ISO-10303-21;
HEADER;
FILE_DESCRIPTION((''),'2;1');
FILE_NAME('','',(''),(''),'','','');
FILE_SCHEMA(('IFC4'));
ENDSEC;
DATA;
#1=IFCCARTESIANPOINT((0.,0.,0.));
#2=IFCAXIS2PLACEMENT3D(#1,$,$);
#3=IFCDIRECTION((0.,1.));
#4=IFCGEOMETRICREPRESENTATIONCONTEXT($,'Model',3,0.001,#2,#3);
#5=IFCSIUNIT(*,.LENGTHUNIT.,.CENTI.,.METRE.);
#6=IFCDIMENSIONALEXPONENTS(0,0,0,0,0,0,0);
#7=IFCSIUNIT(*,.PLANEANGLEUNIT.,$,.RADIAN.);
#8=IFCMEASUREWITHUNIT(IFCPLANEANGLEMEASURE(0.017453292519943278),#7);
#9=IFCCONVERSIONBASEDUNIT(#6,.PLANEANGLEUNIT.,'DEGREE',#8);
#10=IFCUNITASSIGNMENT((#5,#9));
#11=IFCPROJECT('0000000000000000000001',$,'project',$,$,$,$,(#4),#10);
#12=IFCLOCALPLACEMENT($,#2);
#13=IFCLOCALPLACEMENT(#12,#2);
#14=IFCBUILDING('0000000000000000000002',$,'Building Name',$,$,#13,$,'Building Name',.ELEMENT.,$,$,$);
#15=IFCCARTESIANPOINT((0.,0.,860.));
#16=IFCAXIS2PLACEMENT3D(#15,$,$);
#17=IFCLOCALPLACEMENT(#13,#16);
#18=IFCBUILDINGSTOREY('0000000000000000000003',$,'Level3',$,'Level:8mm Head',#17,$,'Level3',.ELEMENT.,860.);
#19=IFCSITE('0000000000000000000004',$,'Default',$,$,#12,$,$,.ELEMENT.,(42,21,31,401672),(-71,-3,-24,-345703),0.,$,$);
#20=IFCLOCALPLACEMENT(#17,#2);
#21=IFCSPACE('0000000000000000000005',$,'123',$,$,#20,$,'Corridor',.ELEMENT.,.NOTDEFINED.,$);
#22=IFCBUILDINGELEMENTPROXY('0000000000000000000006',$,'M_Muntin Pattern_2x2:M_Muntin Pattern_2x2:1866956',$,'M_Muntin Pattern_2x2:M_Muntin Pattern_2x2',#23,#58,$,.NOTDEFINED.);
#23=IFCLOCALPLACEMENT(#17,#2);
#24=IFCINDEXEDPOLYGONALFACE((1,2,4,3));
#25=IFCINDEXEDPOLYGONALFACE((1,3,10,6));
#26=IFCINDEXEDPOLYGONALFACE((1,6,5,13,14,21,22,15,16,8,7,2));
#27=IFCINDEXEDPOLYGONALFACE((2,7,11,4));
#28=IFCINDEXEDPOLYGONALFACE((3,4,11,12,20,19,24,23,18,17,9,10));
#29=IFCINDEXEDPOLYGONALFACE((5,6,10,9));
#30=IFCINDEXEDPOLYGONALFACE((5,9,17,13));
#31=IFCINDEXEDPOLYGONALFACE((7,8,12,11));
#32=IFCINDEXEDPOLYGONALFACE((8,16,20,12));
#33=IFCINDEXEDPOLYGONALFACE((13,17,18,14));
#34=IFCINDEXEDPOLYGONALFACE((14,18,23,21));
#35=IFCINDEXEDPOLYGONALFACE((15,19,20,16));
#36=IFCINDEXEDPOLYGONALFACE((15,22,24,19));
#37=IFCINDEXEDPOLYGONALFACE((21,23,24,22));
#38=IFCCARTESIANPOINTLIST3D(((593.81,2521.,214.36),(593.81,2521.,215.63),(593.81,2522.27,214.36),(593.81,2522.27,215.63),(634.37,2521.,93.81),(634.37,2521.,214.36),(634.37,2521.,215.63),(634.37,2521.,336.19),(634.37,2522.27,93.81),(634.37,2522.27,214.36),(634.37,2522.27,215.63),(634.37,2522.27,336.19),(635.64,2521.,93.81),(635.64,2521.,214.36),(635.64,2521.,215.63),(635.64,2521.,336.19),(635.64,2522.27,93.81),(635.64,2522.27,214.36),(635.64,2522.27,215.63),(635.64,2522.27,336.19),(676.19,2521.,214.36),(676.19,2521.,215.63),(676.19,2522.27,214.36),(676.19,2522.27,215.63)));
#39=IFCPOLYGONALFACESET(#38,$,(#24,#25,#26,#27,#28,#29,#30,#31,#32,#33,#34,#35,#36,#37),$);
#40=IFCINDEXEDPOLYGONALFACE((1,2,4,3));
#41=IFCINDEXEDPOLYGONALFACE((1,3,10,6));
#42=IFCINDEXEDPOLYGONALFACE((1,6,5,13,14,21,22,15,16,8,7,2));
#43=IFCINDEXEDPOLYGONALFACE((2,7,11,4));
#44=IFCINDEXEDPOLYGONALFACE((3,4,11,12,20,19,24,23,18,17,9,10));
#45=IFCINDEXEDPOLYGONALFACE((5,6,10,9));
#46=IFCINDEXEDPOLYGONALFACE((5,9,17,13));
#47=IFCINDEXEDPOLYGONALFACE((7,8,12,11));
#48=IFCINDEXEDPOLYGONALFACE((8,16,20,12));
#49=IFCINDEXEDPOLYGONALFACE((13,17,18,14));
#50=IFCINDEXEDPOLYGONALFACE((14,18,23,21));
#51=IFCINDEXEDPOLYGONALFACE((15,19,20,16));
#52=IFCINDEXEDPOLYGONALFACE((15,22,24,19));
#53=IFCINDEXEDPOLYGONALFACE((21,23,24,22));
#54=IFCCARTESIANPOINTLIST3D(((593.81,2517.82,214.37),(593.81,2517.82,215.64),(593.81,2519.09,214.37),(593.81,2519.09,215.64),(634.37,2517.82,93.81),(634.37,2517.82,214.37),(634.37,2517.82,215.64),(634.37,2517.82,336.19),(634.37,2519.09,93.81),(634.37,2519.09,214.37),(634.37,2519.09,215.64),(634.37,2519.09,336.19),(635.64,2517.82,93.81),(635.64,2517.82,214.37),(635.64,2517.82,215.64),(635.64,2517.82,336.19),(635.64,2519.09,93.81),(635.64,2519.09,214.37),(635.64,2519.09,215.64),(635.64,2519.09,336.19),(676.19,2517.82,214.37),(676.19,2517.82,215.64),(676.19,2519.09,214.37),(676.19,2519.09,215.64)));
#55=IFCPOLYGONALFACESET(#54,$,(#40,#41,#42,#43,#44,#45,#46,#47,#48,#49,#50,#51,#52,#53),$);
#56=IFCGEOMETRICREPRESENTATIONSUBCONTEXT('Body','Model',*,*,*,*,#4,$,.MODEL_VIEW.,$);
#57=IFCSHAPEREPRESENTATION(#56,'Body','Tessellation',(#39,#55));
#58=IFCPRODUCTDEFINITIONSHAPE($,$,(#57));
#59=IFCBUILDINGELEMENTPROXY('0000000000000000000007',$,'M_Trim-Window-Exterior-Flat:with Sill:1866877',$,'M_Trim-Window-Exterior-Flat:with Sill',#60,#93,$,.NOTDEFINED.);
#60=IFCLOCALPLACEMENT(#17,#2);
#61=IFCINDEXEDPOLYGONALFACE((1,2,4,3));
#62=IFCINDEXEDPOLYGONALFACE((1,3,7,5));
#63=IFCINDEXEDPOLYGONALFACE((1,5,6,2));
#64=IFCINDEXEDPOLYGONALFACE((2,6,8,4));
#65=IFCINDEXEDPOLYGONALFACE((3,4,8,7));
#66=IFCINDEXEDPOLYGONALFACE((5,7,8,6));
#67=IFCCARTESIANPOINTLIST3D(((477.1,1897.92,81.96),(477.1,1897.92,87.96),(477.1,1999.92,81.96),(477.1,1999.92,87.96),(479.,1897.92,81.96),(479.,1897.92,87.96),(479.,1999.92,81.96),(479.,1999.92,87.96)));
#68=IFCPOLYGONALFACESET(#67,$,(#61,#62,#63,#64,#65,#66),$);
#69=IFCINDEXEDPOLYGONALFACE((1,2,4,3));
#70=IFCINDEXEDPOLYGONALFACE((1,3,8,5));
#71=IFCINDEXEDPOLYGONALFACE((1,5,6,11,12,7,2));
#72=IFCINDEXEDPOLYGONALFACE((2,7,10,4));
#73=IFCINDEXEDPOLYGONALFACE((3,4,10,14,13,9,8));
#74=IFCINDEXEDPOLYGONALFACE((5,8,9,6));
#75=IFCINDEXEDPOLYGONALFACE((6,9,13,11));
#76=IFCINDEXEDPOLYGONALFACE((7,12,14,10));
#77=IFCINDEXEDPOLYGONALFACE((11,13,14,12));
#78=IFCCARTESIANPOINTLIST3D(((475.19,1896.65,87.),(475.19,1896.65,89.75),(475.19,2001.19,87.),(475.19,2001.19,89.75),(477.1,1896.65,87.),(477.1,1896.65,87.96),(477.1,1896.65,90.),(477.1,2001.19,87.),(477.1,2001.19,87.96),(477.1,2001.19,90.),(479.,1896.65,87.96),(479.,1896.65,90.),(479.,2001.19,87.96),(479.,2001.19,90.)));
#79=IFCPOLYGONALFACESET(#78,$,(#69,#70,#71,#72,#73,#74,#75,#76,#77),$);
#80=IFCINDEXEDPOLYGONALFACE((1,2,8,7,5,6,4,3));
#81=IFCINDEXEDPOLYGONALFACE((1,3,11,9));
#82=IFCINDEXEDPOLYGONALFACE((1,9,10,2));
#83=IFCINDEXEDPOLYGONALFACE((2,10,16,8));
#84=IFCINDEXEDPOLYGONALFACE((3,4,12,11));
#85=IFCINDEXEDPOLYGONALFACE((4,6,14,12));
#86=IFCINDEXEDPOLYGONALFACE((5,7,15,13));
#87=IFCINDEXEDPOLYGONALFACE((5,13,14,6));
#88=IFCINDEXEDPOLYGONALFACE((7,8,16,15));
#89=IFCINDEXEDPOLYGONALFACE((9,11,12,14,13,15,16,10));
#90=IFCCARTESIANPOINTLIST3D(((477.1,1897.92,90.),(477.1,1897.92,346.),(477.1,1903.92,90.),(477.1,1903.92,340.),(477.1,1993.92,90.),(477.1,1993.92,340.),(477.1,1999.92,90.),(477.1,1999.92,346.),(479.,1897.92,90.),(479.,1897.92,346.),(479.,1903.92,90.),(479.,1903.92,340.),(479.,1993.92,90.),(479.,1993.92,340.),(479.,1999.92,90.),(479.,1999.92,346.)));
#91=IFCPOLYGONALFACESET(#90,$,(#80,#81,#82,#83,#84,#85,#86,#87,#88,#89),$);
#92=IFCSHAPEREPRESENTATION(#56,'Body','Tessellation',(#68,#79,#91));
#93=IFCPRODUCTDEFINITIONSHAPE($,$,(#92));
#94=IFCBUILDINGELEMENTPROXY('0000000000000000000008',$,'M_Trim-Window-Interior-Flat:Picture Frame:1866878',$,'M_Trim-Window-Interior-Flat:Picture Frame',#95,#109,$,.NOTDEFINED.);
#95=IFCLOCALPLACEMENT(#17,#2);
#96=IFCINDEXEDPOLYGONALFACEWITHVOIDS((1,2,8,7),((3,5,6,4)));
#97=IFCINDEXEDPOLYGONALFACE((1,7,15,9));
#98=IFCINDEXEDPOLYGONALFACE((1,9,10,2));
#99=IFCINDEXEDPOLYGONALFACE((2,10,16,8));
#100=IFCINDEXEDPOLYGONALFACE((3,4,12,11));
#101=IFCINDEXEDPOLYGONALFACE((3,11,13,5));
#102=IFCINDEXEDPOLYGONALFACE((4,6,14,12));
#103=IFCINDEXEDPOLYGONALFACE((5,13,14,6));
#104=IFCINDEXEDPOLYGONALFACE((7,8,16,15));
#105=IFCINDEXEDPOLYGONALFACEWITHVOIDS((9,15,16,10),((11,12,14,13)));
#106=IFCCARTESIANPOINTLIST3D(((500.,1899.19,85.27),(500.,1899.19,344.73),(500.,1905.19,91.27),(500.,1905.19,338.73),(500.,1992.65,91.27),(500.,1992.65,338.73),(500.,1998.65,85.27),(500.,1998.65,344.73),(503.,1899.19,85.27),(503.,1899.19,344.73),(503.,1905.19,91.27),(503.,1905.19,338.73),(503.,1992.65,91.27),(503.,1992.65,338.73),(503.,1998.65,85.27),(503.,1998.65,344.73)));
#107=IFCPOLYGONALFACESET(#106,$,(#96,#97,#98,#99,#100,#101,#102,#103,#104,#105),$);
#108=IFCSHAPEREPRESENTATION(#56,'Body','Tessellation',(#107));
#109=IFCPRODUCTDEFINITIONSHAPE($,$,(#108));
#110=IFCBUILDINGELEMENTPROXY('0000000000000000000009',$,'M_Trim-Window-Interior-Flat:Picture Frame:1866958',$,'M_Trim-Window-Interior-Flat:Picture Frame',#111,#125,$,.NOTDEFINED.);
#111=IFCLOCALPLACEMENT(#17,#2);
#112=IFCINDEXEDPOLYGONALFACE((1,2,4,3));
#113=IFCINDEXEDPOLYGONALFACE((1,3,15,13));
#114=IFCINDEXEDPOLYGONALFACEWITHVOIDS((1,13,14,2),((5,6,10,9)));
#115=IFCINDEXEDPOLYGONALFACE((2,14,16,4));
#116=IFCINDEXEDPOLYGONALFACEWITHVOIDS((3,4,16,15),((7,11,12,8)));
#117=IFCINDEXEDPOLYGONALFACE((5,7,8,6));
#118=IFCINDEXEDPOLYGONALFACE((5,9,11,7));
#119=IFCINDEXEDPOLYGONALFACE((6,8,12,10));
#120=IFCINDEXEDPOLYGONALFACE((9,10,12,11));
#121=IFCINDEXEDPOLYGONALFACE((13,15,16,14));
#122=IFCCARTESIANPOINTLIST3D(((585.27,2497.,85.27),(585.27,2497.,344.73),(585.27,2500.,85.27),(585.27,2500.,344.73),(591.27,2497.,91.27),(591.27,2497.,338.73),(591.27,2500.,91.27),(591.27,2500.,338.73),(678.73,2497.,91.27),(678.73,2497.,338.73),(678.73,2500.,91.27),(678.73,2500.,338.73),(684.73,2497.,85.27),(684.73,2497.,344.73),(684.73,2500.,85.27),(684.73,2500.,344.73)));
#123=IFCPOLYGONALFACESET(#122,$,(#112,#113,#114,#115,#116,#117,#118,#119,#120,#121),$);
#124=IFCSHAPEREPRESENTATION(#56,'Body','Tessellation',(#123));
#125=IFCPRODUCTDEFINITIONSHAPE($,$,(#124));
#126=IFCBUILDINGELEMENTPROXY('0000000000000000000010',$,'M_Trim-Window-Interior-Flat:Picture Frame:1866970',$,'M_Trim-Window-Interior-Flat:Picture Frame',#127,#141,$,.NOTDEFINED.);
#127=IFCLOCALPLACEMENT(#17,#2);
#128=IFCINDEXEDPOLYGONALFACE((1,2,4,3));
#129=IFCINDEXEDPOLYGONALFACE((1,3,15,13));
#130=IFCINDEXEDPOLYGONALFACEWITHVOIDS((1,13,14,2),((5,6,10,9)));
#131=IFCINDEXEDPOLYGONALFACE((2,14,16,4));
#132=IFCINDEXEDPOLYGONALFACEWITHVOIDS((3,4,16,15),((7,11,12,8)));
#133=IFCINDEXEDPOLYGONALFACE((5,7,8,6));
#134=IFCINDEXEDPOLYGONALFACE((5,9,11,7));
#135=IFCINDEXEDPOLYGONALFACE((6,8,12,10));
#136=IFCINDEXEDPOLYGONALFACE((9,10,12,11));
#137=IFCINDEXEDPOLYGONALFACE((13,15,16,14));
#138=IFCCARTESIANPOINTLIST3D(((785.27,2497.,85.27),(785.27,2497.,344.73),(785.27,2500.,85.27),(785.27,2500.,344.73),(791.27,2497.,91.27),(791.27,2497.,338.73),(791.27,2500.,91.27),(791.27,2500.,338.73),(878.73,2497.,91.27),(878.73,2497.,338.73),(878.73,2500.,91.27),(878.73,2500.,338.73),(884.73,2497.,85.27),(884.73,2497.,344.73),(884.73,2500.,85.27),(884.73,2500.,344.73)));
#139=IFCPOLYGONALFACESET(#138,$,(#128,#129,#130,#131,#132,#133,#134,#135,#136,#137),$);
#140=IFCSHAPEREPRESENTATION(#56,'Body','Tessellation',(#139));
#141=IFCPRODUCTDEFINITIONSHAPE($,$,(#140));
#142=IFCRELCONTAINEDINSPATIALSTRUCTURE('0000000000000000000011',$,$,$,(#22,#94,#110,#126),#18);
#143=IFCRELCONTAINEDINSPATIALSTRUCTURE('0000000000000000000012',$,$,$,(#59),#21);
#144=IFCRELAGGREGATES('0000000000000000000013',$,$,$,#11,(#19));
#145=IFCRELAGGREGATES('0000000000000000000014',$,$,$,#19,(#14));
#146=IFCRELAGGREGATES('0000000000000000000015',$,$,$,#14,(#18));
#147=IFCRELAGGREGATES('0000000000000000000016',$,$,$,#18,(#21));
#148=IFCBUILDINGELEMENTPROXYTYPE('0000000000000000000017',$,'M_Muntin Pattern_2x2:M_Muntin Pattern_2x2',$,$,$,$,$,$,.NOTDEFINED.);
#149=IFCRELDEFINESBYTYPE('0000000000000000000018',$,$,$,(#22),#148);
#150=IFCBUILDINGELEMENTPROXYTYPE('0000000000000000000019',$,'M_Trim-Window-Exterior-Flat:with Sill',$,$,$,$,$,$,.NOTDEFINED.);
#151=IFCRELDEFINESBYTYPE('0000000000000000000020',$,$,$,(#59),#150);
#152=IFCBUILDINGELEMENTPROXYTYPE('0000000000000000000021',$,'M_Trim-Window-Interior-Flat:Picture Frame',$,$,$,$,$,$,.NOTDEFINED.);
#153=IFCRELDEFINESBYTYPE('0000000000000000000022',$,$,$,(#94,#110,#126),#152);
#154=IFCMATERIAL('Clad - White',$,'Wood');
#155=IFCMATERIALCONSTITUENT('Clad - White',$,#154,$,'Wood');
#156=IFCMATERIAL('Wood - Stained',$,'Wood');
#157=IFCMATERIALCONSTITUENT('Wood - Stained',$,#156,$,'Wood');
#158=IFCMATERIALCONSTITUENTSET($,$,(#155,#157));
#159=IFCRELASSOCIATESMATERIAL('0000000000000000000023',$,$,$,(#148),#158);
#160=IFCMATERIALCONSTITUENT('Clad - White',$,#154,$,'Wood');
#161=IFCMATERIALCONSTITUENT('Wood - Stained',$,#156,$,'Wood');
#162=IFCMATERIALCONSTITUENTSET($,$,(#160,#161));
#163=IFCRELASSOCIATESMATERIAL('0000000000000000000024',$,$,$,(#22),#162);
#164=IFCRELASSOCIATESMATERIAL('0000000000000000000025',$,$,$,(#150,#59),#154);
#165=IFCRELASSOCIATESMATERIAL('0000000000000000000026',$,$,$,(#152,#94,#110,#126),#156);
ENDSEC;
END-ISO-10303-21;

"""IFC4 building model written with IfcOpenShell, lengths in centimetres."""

from ifc_helpers import new_model, entity, si_unit, converted_unit, direction, frame, origin, place, context, subcontext, project, spatial, indexed_curve, outline, extrude, source, transform, mapped, material, constituent, constituent_set, type_object, type_shapes, element, save


model = new_model("IFC4")

# Units and contexts
model_context = context("Model", 3, precision=0.001, world=origin(), true_north=direction((0.0, 1.0)))
body_context = subcontext(model_context, "Body", "Model", "MODEL_VIEW")
ifc_project = project(units=[si_unit("LENGTHUNIT", "METRE", prefix="CENTI"), converted_unit("PLANEANGLEUNIT", "DEGREE", entity("IfcPlaneAngleMeasure", 0.017453292519943278), si_unit("PLANEANGLEUNIT", "RADIAN"), dimensions=[0, 0, 0, 0, 0, 0, 0])], contexts=[model_context])

# Site, building, storey
site_placement = place(None, origin())
site = spatial("IfcSite", under=ifc_project, at=site_placement, Name="Default", CompositionType="ELEMENT", RefLatitude=(42, 21, 31, 401672), RefLongitude=(-71, -3, -24, -345703), RefElevation=0.0)
building_placement = place(site_placement, origin())
building = spatial("IfcBuilding", under=site, at=building_placement, Name="Building Name", LongName="Building Name", CompositionType="ELEMENT")
storey_placement = place(building_placement, frame((0.0, 0.0, 860.0)))
storey = spatial("IfcBuildingStorey", under=building, at=storey_placement, Name="Level3", ObjectType="Level:8mm Head", LongName="Level3", CompositionType="ELEMENT", Elevation=860.0)

# Shared definitions
ifc_material_1 = material(Name="Clad - White", Category="Wood")
ifc_material_2 = material(Name="Wood - Stained", Category="Wood")

# Shared definitions
space_1_placement = place(storey_placement, origin())
space_1 = spatial("IfcSpace", under=storey, at=space_1_placement, Name="123", LongName="Corridor", CompositionType="ELEMENT", PredefinedType="NOTDEFINED")

# Building element proxies
ifc_constituent_1 = constituent(ifc_material_1, Name="Clad - White", Category="Wood")
ifc_constituent_2 = constituent(ifc_material_2, Name="Wood - Stained", Category="Wood")
ifc_constituent_set_1 = constituent_set(constituents=[ifc_constituent_1, ifc_constituent_2])
building_element_proxy_type_1 = type_object("IfcBuildingElementProxyType", Name="M_Muntin Pattern_2x2:M_Muntin Pattern_2x2", PredefinedType="NOTDEFINED", material=ifc_constituent_set_1)
shared_shape_1 = source(origin(), body_context, "Body", "SweptSolid", [
    extrude(outline(indexed_curve([(0.64, -0.64), (121.19, -0.64), (121.19, 0.63), (0.64, 0.63), (0.64, 41.19), (-0.63, 41.19), (-0.63, 0.63), (-121.19, 0.63), (-121.19, -0.64), (-0.63, -0.64), (-0.63, -41.19), (0.64, -41.19), (0.64, -0.64)], self_intersect=False)), frame((0.0, -2.22, 121.19), z_axis=(0.0, 1.0, 0.0), x_axis=(0.0, 0.0, 1.0)), (0.0, 0.0, 1.0), 1.27),
    extrude(outline(indexed_curve([(0.64, -0.64), (121.19, -0.64), (121.19, 0.63), (0.64, 0.63), (0.64, 41.19), (-0.63, 41.19), (-0.63, 0.63), (-121.19, 0.63), (-121.19, -0.64), (-0.63, -0.64), (-0.63, -41.19), (0.64, -41.19), (0.64, -0.64)], self_intersect=False)), frame((0.0, 0.95, 121.19), z_axis=(0.0, 1.0, 0.0), x_axis=(0.0, 0.0, 1.0)), (0.0, 0.0, 1.0), 1.27),
])
type_shapes(building_element_proxy_type_1, [shared_shape_1])
ifc_constituent_3 = constituent(ifc_material_1, Name="Clad - White", Category="Wood")
ifc_constituent_4 = constituent(ifc_material_2, Name="Wood - Stained", Category="Wood")
ifc_constituent_set_2 = constituent_set(constituents=[ifc_constituent_3, ifc_constituent_4])
proxy_1_placement = place(storey_placement, frame((635.0, 2520.05, 93.81), z_axis=(0.0, 0.0, 1.0), x_axis=(-1.0, 0.0, 0.0)))
element("IfcBuildingElementProxy", 1, at=proxy_1_placement, inside=storey, type_object=building_element_proxy_type_1, material=ifc_constituent_set_2, Name="M_Muntin Pattern_2x2:M_Muntin Pattern_2x2:1866956", ObjectType="M_Muntin Pattern_2x2:M_Muntin Pattern_2x2", PredefinedType="NOTDEFINED", context=body_context, shape_type="MappedRepresentation", body=[
    mapped(shared_shape_1, transform((0.0, 0.0, 0.0), scale=1.0)),
])
building_element_proxy_type_2 = type_object("IfcBuildingElementProxyType", Name="M_Trim-Window-Exterior-Flat:with Sill", PredefinedType="NOTDEFINED", material=ifc_material_1)
shared_shape_2 = source(origin(), body_context, "Body", "SweptSolid", [
    extrude(outline(indexed_curve([(-51.0, -3.0), (51.0, -3.0), (51.0, 3.0), (-51.0, 3.0), (-51.0, -3.0)], self_intersect=False)), frame((0.0, -255.04, 0.0), z_axis=(0.0, 0.0, 1.0), x_axis=(-1.0, 0.0, 0.0)), (0.0, 0.0, 1.0), 1.9),
    extrude(outline(indexed_curve([(-1.9, -1.52), (0.0, -1.52), (0.0, -0.57), (1.9, -0.57), (1.9, 1.48), (0.0, 1.48), (-1.9, 1.23), (-1.9, -1.52)], self_intersect=False)), frame((-52.27, -251.48, 1.9), z_axis=(1.0, 0.0, 0.0), x_axis=(0.0, 0.0, -1.0)), (0.0, 0.0, 1.0), 104.54),
    extrude(outline(indexed_curve([(-129.5, -51.0), (126.5, -51.0), (126.5, -45.0), (-123.5, -45.0), (-123.5, 45.0), (126.5, 45.0), (126.5, 51.0), (-129.5, 51.0), (-129.5, -51.0)], self_intersect=False)), frame((0.0, -123.5, 0.0), z_axis=(0.0, 0.0, 1.0), x_axis=(0.0, -1.0, 0.0)), (0.0, 0.0, 1.0), 1.9),
])
type_shapes(building_element_proxy_type_2, [shared_shape_2])
proxy_2_placement = place(space_1_placement, frame((479.0, 1948.92, 340.0), z_axis=(-1.0, 0.0, 0.0), x_axis=(0.0, -1.0, 0.0)))
element("IfcBuildingElementProxy", 2, at=proxy_2_placement, inside=space_1, type_object=building_element_proxy_type_2, material=ifc_material_1, Name="M_Trim-Window-Exterior-Flat:with Sill:1866877", ObjectType="M_Trim-Window-Exterior-Flat:with Sill", PredefinedType="NOTDEFINED", context=body_context, shape_type="MappedRepresentation", body=[
    mapped(shared_shape_2, transform((0.0, 0.0, 0.0), scale=1.0)),
])
building_element_proxy_type_3 = type_object("IfcBuildingElementProxyType", Name="M_Trim-Window-Interior-Flat:Picture Frame", PredefinedType="NOTDEFINED", material=ifc_material_2)
shared_shape_3 = source(origin(), body_context, "Body", "SweptSolid", [
    extrude(outline(indexed_curve([(-49.73, -129.73), (49.73, -129.73), (49.73, 129.73), (-49.73, 129.73), (-49.73, -129.73)], self_intersect=False), holes=[indexed_curve([(-43.73, -123.73), (-43.73, 123.73), (43.73, 123.73), (43.73, -123.73), (-43.73, -123.73)], self_intersect=False)]), frame((0.0, -125.0, 0.0), z_axis=(0.0, 0.0, 1.0), x_axis=(-1.0, 0.0, 0.0)), (0.0, 0.0, 1.0), 3.0),
])
type_shapes(building_element_proxy_type_3, [shared_shape_3])
for number, where, z_axis, x_axis, name in (
    (3, (500.0, 1948.92, 340.0), (1.0, 0.0, 0.0), (0.0, 1.0, 0.0), "M_Trim-Window-Interior-Flat:Picture Frame:1866878"),
    (4, (635.0, 2500.0, 340.0), (0.0, -1.0, 0.0), (1.0, 0.0, 0.0), "M_Trim-Window-Interior-Flat:Picture Frame:1866958"),
    (5, (835.0, 2500.0, 340.0), (0.0, -1.0, 0.0), (1.0, 0.0, 0.0), "M_Trim-Window-Interior-Flat:Picture Frame:1866970"),
):
    element("IfcBuildingElementProxy", number, at=place(storey_placement, frame(where, z_axis=z_axis, x_axis=x_axis)), inside=storey, type_object=building_element_proxy_type_3, material=ifc_material_2, Name=name, ObjectType="M_Trim-Window-Interior-Flat:Picture Frame", PredefinedType="NOTDEFINED", context=body_context, shape_type="MappedRepresentation", body=[
        mapped(shared_shape_3, transform((0.0, 0.0, 0.0), scale=1.0)),
    ])

save(model, "model.ifc")
